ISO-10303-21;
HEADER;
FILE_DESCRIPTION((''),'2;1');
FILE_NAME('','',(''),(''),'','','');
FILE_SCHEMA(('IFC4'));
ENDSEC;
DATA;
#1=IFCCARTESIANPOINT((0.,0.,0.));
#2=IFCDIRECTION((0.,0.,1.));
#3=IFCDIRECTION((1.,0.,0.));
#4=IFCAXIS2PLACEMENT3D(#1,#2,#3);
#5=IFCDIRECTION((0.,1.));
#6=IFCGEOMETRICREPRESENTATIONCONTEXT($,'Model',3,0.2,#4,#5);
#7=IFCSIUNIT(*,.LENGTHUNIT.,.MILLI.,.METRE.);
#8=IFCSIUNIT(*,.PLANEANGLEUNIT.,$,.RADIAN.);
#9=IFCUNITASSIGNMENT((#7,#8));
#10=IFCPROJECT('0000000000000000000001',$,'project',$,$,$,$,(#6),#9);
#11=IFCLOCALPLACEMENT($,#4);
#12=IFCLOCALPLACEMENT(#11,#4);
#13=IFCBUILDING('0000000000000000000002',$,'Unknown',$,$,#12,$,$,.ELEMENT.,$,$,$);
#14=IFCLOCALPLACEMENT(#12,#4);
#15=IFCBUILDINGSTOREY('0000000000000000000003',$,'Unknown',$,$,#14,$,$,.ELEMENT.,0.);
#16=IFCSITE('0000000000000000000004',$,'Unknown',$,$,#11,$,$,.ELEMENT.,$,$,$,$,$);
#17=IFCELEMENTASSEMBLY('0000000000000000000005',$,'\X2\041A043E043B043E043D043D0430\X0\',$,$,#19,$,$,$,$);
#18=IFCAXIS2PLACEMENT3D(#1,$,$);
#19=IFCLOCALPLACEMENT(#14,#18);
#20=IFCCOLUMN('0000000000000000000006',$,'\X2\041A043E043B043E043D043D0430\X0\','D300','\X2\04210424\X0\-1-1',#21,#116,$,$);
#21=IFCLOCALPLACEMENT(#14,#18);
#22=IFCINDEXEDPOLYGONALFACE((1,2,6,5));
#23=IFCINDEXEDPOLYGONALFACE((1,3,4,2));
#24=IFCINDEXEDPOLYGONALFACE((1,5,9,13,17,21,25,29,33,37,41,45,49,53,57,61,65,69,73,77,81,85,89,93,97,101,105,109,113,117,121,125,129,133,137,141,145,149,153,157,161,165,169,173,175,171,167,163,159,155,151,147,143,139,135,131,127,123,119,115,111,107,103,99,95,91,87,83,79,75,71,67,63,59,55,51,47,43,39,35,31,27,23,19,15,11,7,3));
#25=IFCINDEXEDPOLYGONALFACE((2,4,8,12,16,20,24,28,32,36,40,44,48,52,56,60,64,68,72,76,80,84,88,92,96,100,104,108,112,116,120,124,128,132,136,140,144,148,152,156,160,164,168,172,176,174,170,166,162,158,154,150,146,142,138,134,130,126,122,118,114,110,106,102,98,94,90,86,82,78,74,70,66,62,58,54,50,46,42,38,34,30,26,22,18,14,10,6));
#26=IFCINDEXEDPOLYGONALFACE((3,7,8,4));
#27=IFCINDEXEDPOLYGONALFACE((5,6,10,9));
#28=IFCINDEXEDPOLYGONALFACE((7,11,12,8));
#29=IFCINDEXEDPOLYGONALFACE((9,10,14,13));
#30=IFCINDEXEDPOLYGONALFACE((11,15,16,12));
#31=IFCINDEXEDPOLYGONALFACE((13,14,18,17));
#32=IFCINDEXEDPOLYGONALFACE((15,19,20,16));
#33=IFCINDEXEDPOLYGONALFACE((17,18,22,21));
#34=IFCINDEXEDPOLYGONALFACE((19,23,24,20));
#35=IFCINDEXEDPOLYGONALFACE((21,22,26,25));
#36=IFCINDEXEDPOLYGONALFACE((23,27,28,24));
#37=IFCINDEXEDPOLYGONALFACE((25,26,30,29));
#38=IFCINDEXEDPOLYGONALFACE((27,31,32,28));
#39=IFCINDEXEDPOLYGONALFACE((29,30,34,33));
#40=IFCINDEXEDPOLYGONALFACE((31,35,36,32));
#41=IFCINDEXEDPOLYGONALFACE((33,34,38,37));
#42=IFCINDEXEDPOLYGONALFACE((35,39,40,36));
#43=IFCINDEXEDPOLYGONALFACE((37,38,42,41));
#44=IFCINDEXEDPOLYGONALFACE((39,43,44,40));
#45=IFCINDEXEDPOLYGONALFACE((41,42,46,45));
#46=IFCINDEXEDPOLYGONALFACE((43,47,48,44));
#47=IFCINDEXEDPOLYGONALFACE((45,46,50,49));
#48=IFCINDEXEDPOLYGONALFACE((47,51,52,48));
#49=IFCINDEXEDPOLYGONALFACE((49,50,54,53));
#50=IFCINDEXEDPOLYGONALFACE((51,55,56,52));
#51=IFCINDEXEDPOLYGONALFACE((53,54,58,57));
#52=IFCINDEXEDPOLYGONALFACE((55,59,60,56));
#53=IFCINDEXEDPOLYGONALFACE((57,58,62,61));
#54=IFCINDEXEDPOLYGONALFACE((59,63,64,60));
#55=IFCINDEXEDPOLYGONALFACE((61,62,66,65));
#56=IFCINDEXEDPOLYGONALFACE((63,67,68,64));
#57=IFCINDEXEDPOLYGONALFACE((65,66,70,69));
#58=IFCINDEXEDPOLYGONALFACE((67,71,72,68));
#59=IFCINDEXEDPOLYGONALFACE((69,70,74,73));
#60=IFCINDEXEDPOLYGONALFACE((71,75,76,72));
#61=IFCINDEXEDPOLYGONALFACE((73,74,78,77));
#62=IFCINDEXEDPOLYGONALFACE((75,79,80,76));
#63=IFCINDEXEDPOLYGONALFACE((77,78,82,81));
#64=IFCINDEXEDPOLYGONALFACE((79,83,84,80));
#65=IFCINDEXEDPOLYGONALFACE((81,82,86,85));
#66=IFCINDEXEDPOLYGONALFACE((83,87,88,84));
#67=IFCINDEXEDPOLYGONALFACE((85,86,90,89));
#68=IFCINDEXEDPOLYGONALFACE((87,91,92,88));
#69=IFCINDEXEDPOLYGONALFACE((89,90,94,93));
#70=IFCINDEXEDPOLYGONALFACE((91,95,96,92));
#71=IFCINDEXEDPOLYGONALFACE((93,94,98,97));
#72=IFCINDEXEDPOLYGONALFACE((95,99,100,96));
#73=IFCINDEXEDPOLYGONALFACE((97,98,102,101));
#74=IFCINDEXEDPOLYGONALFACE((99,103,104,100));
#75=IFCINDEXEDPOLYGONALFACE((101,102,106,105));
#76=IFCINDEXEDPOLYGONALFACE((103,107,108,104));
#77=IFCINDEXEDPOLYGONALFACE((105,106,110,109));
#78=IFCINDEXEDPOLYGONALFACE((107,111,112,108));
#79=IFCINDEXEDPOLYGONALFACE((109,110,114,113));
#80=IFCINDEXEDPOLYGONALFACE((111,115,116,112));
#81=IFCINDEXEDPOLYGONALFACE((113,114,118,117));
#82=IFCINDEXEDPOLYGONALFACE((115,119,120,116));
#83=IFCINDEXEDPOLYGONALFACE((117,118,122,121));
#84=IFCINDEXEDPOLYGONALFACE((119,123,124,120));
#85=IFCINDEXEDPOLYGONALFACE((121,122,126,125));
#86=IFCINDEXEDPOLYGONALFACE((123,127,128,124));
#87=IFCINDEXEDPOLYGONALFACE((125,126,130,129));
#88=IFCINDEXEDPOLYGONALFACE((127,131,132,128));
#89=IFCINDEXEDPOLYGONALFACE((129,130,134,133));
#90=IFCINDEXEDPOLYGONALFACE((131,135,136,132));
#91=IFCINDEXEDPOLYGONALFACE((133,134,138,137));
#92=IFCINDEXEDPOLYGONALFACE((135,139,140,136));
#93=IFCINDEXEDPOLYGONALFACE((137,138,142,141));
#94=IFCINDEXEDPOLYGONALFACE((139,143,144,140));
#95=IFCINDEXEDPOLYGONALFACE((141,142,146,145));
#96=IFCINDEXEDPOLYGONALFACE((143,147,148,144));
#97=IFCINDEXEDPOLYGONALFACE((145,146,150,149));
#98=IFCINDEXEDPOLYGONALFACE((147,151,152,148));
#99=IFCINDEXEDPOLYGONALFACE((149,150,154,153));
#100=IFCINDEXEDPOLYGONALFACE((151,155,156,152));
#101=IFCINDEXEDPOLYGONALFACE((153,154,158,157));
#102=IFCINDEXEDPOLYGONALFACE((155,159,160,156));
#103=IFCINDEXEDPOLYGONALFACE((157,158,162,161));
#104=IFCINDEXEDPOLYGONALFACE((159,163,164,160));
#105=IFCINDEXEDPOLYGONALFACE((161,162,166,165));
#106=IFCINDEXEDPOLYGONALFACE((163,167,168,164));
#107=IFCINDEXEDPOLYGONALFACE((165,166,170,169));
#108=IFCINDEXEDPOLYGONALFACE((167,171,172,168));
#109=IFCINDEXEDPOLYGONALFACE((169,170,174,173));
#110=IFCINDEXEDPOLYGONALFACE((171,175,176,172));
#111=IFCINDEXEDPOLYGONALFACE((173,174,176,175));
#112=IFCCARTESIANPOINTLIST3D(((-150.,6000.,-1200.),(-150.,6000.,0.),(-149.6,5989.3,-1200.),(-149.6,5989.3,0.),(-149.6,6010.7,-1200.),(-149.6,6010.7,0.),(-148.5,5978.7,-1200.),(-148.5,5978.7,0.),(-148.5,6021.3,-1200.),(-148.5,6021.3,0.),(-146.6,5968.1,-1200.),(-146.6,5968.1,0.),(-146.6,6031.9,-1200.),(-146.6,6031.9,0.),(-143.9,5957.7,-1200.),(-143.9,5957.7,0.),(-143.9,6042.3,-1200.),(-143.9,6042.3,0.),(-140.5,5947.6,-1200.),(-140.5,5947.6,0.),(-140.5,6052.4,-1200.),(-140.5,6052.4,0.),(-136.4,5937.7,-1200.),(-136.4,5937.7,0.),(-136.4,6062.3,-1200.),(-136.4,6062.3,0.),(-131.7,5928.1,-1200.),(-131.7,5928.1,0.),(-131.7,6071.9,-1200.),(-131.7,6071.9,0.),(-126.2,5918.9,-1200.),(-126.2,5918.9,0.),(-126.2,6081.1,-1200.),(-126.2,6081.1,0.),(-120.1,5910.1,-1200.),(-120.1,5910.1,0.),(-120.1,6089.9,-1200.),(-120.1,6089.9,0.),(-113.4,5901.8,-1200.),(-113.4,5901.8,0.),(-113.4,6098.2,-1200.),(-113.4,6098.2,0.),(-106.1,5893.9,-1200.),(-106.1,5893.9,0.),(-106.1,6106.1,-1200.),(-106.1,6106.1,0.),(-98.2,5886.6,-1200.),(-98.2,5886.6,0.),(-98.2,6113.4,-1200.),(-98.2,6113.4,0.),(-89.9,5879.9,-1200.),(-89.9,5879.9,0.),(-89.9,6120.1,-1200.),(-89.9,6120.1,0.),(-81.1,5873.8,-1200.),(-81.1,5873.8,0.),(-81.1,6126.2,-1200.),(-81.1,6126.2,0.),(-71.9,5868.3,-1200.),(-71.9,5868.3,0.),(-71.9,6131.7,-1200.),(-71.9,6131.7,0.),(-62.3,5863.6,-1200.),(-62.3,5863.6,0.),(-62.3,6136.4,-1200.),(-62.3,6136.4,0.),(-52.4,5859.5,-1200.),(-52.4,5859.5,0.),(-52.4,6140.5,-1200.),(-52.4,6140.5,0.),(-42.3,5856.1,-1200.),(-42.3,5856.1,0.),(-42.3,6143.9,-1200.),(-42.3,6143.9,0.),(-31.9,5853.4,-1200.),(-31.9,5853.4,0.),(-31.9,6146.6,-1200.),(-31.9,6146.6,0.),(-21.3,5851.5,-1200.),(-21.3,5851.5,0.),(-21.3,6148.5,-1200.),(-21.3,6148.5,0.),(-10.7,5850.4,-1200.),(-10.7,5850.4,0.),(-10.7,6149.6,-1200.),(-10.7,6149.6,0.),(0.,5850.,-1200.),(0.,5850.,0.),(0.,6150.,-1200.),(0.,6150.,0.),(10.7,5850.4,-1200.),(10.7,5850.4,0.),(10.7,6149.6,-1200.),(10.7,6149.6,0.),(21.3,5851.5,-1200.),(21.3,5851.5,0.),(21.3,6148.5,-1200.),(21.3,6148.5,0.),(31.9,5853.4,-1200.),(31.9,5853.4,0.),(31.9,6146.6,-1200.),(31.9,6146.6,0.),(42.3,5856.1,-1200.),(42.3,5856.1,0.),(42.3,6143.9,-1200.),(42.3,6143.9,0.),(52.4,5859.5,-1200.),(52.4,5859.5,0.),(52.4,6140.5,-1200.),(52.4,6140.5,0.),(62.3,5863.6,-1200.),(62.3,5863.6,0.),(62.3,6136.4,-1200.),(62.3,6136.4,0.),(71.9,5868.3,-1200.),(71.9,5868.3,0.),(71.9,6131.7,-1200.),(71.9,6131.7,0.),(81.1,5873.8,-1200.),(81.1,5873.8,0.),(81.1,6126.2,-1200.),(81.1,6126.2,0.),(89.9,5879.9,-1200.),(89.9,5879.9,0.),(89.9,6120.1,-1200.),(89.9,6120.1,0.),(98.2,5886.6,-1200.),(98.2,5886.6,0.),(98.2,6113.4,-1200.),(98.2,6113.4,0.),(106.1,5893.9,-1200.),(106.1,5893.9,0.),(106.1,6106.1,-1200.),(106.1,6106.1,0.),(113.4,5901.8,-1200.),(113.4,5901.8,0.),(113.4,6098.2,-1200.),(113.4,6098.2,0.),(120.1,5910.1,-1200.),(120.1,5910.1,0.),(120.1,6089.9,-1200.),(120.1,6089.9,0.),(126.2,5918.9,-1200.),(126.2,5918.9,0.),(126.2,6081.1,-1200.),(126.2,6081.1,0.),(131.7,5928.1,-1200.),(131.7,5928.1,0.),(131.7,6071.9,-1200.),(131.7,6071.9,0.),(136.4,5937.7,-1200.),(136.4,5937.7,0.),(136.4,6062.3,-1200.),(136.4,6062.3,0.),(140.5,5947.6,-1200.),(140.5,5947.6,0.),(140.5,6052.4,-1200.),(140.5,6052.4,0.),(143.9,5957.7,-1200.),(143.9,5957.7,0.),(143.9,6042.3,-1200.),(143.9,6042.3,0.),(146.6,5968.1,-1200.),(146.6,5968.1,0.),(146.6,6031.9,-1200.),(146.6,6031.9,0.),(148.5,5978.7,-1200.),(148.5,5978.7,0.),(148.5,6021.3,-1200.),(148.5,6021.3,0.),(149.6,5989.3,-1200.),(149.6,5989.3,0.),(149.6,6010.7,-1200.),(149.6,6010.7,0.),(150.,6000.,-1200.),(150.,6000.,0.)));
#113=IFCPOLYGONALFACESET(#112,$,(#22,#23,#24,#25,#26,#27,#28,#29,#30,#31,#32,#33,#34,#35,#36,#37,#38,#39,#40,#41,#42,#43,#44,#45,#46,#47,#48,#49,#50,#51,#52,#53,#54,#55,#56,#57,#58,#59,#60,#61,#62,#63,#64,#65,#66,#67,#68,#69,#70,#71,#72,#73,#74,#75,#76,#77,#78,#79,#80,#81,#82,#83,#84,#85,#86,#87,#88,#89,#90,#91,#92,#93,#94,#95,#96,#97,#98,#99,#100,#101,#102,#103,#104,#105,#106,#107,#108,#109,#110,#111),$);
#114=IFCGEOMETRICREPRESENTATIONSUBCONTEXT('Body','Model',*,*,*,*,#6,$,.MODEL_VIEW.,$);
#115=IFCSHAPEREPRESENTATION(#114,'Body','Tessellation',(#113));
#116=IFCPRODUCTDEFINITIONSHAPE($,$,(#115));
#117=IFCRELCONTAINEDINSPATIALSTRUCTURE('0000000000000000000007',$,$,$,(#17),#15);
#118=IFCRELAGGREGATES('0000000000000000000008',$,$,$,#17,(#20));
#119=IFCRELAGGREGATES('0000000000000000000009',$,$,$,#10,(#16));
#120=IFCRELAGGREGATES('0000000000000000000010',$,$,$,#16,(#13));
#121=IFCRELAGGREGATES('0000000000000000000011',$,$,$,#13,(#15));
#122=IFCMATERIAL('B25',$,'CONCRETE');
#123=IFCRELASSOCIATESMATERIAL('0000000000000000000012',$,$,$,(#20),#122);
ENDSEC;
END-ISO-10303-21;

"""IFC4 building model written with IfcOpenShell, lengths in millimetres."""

from ifc_helpers import new_model, si_unit, direction, frame, origin_with_axes, place, context, subcontext, project, spatial, line, indexed_curve, outline, extrude, material, element, aggregate, save


model = new_model("IFC4")

# Units and contexts
model_context = context("Model", 3, precision=0.2, world=origin_with_axes(), true_north=direction((0.0, 1.0)))
body_context = subcontext(model_context, "Body", "Model", "MODEL_VIEW")
ifc_project = project(units=[si_unit("LENGTHUNIT", "METRE", prefix="MILLI"), si_unit("PLANEANGLEUNIT", "RADIAN")], contexts=[model_context])

# Site, building, storey
site_placement = place(None, origin_with_axes())
site = spatial("IfcSite", under=ifc_project, at=site_placement, Name="Unknown", CompositionType="ELEMENT")
building_placement = place(site_placement, origin_with_axes())
building = spatial("IfcBuilding", under=site, at=building_placement, Name="Unknown", CompositionType="ELEMENT")
storey_placement = place(building_placement, origin_with_axes())
storey = spatial("IfcBuildingStorey", under=building, at=storey_placement, Name="Unknown", CompositionType="ELEMENT", Elevation=0.0)

# Element assembly, column
assembly_1_placement = place(storey_placement, frame((0.0, 6000.0, -1200.0), z_axis=(-1.0, 0.0, 0.0), x_axis=(0.0, 0.0, 1.0)))
assembly_1 = element("IfcElementAssembly", 1, at=assembly_1_placement, inside=storey, Name="Колонна")
ifc_material_1 = material(Name="B25", Category="CONCRETE")
column_1_placement = place(assembly_1_placement, origin_with_axes())
column_1 = element("IfcColumn", 2, at=column_1_placement, material=ifc_material_1, Name="Колонна", Description="D300", ObjectType="СФ-1-1", context=body_context, shape_type="SolidModel", body=[
    extrude(outline(indexed_curve([(150.0, 0.0), (149.6, 10.7), (148.5, 21.3), (146.6, 31.9), (143.9, 42.3), (140.5, 52.4), (136.4, 62.3), (131.7, 71.9), (126.2, 81.1), (120.1, 89.9), (113.4, 98.2), (106.1, 106.1), (98.2, 113.4), (89.9, 120.1), (81.1, 126.2), (71.9, 131.7), (62.3, 136.4), (52.4, 140.5), (42.3, 143.9), (31.9, 146.6), (21.3, 148.5), (10.7, 149.6), (0.0, 150.0), (-10.7, 149.6), (-21.3, 148.5), (-31.9, 146.6), (-42.3, 143.9), (-52.4, 140.5), (-62.3, 136.4), (-71.9, 131.7), (-81.1, 126.2), (-89.9, 120.1), (-98.2, 113.4), (-106.1, 106.1), (-113.4, 98.2), (-120.1, 89.9), (-126.2, 81.1), (-131.7, 71.9), (-136.4, 62.3), (-140.5, 52.4), (-143.9, 42.3), (-146.6, 31.9), (-148.5, 21.3), (-149.6, 10.7), (-150.0, 0.0), (-149.6, -10.7), (-148.5, -21.3), (-146.6, -31.9), (-143.9, -42.3), (-140.5, -52.4), (-136.4, -62.3), (-131.7, -71.9), (-126.2, -81.1), (-120.1, -89.9), (-113.4, -98.2), (-106.1, -106.1), (-98.2, -113.4), (-89.9, -120.1), (-81.1, -126.2), (-71.9, -131.7), (-62.3, -136.4), (-52.4, -140.5), (-42.3, -143.9), (-31.9, -146.6), (-21.3, -148.5), (-10.7, -149.6), (0.0, -150.0), (10.7, -149.6), (21.3, -148.5), (31.9, -146.6), (42.3, -143.9), (52.4, -140.5), (62.3, -136.4), (71.9, -131.7), (81.1, -126.2), (89.9, -120.1), (98.2, -113.4), (106.1, -106.1), (113.4, -98.2), (120.1, -89.9), (126.2, -81.1), (131.7, -71.9), (136.4, -62.3), (140.5, -52.4), (143.9, -42.3), (146.6, -31.9), (148.5, -21.3), (149.6, -10.7)], segments=[line(1, 2, 3, 4, 5, 6, 7, 8, 9, 10, 11, 12, 13, 14, 15, 16, 17, 18, 19, 20, 21, 22, 23, 24, 25, 26, 27, 28, 29, 30, 31, 32, 33, 34, 35, 36, 37, 38, 39, 40, 41, 42, 43, 44, 45, 46, 47, 48, 49, 50, 51, 52, 53, 54, 55, 56, 57, 58, 59, 60, 61, 62, 63, 64, 65, 66, 67, 68, 69, 70, 71, 72, 73, 74, 75, 76, 77, 78, 79, 80, 81, 82, 83, 84, 85, 86, 87, 88, 1)])), frame((0.0, 0.0, 0.0), z_axis=(-1.0, 0.0, 0.0), x_axis=(0.0, 0.0, 1.0)), (0.0, 0.0, -1.0), 1200.0),
])
aggregate(assembly_1, [column_1])

save(model, "model.ifc")
